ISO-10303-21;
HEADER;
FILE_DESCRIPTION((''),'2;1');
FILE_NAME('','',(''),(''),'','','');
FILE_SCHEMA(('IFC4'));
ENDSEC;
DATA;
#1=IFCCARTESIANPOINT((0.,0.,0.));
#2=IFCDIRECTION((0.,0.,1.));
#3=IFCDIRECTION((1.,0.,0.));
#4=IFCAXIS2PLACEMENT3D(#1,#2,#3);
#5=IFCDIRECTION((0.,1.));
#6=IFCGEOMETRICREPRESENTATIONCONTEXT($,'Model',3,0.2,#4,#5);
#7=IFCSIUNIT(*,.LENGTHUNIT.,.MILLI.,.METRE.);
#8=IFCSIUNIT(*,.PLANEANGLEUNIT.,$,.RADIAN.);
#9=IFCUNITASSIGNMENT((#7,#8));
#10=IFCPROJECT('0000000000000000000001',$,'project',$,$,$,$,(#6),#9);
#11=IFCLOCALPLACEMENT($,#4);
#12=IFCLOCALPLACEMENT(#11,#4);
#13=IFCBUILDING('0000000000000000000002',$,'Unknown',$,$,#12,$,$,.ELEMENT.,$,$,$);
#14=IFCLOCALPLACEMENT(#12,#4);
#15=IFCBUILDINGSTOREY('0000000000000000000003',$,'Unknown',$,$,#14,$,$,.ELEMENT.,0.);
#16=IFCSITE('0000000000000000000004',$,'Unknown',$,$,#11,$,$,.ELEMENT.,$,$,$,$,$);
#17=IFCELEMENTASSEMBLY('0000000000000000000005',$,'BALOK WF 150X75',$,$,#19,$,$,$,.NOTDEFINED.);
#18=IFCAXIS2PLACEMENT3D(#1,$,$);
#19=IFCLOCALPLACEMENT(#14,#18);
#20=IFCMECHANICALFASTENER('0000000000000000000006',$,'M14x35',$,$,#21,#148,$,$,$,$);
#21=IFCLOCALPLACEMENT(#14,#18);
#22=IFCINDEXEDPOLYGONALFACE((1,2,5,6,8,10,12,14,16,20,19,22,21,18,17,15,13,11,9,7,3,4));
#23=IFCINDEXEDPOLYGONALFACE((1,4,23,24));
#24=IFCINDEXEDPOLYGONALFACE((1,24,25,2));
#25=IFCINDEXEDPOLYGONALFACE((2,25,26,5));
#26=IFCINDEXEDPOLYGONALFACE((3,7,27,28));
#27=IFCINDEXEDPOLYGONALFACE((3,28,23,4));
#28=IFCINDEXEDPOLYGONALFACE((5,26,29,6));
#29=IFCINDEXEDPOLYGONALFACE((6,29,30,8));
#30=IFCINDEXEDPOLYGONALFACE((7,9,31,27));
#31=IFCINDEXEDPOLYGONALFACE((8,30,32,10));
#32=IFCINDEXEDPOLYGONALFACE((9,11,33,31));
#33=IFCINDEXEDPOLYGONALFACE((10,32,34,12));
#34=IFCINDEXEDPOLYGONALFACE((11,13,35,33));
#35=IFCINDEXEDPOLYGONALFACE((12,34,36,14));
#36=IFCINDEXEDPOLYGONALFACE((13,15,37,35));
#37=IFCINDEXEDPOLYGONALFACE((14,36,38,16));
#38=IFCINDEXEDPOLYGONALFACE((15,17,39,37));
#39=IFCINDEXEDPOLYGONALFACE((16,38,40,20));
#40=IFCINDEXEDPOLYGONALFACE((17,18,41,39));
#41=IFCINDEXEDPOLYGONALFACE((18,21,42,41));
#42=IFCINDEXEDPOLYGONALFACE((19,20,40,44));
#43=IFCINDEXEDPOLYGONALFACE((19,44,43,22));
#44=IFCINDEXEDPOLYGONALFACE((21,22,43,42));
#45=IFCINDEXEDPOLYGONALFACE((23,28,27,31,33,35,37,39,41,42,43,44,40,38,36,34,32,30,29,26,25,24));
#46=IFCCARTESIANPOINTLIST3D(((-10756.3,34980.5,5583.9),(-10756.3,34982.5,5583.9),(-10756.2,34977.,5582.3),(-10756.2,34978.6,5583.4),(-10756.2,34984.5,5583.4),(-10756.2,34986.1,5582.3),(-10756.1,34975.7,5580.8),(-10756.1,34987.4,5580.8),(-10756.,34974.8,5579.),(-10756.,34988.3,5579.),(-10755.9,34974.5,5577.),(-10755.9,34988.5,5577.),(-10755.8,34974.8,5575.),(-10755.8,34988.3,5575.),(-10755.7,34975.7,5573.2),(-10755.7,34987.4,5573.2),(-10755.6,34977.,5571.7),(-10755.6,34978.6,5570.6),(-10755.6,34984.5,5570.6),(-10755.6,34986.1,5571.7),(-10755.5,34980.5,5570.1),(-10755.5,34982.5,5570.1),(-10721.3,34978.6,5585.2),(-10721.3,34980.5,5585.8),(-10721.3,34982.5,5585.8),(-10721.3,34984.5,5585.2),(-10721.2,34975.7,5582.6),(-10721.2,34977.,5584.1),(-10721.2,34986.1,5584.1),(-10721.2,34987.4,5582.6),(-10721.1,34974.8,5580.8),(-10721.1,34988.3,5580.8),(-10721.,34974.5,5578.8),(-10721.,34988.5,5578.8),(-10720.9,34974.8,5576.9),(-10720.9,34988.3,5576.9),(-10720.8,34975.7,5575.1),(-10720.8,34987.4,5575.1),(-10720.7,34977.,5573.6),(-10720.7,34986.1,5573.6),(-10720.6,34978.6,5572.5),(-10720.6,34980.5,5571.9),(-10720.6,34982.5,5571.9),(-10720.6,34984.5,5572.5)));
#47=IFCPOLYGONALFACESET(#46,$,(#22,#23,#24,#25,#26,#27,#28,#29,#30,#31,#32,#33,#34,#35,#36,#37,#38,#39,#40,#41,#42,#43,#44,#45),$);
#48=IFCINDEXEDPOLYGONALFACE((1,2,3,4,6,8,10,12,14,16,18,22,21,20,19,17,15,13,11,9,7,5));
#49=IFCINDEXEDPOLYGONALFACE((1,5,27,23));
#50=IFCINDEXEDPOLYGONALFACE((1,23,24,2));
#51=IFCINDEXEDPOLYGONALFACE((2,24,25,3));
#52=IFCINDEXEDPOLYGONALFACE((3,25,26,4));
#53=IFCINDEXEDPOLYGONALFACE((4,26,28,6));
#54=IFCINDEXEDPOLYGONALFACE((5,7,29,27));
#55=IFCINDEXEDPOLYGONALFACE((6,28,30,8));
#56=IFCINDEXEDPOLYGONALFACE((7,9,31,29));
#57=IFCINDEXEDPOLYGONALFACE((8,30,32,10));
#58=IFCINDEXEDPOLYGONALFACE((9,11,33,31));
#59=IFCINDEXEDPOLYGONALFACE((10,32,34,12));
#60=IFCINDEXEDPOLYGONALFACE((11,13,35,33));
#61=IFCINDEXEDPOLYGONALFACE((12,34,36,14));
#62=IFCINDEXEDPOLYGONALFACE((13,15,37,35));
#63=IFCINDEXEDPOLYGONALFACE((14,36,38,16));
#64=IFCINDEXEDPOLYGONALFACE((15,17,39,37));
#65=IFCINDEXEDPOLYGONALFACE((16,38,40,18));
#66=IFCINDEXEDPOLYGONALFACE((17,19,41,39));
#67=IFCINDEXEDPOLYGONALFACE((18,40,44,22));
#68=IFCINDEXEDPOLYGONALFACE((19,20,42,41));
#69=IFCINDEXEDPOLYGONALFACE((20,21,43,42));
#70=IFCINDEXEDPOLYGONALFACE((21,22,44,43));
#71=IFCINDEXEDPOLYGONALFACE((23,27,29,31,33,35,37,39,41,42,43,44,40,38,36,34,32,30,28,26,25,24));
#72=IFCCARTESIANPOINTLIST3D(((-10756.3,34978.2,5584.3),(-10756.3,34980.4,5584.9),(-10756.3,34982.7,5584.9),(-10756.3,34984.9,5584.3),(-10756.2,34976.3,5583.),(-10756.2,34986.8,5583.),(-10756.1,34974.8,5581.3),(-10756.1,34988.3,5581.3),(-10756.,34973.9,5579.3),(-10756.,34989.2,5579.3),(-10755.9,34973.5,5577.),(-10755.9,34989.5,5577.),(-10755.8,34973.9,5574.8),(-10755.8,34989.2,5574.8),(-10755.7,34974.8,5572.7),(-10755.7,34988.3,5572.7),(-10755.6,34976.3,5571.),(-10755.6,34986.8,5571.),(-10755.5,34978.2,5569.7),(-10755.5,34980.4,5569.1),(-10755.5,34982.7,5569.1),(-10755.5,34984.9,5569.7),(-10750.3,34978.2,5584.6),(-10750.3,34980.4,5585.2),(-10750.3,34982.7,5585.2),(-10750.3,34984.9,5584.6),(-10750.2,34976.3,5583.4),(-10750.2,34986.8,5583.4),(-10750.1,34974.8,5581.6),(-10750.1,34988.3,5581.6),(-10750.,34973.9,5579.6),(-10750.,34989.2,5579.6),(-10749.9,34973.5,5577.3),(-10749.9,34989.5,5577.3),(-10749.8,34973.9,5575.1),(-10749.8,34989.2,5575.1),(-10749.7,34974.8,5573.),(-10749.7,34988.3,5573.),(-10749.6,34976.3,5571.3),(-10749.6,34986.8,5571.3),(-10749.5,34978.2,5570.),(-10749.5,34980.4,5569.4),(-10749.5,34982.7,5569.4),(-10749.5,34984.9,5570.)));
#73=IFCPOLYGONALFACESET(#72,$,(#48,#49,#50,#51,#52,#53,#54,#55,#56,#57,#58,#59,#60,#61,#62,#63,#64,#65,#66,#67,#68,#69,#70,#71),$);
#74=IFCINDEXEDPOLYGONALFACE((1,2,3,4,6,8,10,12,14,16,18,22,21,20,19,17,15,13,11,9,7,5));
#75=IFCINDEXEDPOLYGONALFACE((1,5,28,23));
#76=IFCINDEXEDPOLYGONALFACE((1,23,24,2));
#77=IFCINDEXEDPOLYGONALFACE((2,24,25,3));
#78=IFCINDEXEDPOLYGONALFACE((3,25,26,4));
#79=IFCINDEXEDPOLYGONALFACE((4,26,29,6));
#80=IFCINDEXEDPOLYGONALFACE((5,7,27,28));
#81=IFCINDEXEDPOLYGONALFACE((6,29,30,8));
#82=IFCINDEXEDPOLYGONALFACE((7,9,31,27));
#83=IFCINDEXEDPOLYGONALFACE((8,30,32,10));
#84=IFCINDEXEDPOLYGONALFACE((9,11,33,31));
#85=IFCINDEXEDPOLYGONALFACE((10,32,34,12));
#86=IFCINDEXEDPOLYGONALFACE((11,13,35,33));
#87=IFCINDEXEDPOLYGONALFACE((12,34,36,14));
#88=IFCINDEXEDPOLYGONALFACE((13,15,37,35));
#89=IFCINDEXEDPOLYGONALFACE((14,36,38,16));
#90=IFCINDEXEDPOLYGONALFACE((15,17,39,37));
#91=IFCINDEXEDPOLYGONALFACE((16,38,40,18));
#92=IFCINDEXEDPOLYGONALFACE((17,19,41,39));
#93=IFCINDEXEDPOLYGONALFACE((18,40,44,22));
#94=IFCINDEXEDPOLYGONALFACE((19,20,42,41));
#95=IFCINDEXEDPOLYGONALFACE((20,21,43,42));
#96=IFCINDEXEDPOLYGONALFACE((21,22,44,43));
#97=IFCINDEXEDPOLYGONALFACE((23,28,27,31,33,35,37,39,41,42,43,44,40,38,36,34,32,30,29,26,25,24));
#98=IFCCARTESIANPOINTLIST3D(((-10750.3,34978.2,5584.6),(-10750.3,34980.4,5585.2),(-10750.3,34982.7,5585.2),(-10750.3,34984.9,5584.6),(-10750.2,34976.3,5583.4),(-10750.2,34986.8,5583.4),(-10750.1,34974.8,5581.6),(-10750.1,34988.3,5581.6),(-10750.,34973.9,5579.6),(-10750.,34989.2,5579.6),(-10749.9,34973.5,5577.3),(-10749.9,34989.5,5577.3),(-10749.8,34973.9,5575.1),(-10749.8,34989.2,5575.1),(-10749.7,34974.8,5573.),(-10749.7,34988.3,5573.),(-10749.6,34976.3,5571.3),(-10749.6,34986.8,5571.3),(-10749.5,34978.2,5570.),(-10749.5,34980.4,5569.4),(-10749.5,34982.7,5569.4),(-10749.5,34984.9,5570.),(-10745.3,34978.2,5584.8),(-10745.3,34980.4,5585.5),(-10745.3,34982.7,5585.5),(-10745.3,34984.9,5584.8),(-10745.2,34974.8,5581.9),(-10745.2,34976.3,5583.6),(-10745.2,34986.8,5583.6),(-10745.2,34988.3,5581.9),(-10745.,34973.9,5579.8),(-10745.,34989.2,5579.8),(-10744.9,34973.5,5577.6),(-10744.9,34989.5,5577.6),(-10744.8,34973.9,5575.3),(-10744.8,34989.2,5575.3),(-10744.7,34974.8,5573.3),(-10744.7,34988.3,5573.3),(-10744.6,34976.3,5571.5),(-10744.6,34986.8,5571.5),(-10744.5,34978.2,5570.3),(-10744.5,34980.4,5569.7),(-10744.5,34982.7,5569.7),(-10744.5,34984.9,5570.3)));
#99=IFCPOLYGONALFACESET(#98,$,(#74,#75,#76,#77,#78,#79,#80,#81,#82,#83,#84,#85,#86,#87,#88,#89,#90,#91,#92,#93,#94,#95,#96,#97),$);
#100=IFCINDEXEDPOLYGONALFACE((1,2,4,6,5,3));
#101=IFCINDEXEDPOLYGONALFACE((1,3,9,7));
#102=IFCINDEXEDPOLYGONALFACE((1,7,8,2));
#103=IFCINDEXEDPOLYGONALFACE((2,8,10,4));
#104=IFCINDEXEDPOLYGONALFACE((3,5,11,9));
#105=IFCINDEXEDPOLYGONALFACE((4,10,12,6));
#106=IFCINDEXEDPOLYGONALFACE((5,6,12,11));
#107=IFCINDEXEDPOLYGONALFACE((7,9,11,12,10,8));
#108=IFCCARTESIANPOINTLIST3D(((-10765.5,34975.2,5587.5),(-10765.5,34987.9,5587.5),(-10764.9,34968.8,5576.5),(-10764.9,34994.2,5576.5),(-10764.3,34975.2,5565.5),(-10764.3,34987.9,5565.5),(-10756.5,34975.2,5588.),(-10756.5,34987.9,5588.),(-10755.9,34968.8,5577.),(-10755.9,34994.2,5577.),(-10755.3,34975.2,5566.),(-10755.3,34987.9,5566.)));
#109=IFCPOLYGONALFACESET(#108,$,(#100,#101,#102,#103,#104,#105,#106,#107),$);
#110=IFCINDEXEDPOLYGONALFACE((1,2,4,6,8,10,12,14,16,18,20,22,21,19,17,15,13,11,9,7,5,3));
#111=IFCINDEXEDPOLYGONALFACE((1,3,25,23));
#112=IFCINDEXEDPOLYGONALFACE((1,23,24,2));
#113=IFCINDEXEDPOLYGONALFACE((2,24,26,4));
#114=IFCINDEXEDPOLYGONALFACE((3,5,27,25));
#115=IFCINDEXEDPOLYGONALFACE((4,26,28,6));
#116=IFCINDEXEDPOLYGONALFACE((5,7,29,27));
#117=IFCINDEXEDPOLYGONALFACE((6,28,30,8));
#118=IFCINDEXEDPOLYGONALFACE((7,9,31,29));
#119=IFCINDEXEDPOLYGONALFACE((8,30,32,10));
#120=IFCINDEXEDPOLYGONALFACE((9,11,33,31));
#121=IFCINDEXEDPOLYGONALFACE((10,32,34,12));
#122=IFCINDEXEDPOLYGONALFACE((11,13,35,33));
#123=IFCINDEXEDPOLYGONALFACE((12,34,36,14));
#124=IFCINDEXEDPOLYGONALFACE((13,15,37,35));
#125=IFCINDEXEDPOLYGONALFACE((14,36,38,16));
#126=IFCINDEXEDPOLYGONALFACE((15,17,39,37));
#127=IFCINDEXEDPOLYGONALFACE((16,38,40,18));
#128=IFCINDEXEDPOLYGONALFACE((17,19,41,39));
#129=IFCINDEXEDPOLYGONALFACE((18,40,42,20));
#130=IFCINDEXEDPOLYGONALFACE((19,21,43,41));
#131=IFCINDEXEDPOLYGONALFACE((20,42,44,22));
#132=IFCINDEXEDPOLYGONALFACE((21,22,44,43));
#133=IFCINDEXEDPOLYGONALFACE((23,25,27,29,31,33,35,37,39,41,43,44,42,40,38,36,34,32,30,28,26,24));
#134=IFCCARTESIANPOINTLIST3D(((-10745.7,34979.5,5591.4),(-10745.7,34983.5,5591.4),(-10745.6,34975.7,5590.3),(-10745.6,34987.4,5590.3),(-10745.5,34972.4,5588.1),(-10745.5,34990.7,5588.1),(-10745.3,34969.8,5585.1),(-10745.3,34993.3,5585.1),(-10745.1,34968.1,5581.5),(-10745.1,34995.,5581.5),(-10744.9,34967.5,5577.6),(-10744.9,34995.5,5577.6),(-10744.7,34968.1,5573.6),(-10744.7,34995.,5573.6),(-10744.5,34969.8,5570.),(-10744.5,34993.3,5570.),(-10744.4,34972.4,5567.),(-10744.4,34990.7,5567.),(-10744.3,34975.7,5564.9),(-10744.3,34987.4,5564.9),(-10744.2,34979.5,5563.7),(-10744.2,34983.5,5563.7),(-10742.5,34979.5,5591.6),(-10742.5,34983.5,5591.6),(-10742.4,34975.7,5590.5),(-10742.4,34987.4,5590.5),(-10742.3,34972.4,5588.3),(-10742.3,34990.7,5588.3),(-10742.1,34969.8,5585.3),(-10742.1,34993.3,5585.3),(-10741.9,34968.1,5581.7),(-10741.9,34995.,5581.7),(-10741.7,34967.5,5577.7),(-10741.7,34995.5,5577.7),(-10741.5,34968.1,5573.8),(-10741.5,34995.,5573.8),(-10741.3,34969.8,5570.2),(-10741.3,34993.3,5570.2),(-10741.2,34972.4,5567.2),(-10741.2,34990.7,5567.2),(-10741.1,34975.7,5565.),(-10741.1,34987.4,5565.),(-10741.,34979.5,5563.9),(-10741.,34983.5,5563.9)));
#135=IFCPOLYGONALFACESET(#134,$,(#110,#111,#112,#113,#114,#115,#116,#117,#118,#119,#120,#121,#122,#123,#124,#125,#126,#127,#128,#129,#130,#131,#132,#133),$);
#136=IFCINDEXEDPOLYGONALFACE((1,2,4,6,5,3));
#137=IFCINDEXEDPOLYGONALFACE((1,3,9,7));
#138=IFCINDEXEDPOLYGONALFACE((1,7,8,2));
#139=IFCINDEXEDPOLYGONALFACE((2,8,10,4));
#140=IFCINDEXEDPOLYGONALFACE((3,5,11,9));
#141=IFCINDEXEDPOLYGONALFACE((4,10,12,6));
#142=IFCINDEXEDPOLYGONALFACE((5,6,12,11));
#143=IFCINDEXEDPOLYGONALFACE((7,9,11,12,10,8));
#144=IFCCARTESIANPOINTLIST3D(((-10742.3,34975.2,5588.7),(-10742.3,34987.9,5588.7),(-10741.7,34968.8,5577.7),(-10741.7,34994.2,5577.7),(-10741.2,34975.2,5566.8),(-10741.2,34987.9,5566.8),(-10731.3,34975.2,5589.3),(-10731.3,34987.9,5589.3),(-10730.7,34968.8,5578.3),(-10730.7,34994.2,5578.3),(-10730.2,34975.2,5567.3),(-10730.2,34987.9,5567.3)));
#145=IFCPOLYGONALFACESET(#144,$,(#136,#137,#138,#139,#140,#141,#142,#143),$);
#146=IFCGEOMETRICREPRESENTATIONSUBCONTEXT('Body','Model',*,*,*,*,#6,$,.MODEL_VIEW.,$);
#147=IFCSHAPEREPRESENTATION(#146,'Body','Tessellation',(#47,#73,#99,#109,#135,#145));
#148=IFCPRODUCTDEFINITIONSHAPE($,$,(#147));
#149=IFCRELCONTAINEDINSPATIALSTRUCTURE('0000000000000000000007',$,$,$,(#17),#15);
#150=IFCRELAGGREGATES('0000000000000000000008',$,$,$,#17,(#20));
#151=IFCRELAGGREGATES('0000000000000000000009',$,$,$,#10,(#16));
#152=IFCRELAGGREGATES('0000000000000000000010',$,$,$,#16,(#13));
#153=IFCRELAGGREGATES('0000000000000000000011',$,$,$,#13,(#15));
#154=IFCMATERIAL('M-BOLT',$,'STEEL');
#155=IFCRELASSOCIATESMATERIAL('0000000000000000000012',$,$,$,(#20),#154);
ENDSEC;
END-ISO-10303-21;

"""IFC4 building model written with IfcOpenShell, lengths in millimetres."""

from ifc_helpers import new_model, si_unit, direction, frame, origin_with_axes, place, context, subcontext, project, spatial, line, arc, indexed_curve, outline, extrude, source, transform, mapped, material, element, aggregate, save


model = new_model("IFC4")

# Units and contexts
model_context = context("Model", 3, precision=0.2, world=origin_with_axes(), true_north=direction((0.0, 1.0)))
body_context = subcontext(model_context, "Body", "Model", "MODEL_VIEW")
ifc_project = project(units=[si_unit("LENGTHUNIT", "METRE", prefix="MILLI"), si_unit("PLANEANGLEUNIT", "RADIAN")], contexts=[model_context])

# Site, building, storey
site_placement = place(None, origin_with_axes())
site = spatial("IfcSite", under=ifc_project, at=site_placement, Name="Unknown", CompositionType="ELEMENT")
building_placement = place(site_placement, origin_with_axes())
building = spatial("IfcBuilding", under=site, at=building_placement, Name="Unknown", CompositionType="ELEMENT")
storey_placement = place(building_placement, origin_with_axes())
storey = spatial("IfcBuildingStorey", under=building, at=storey_placement, Name="Unknown", CompositionType="ELEMENT", Elevation=0.0)

# Shared definitions
ifc_material_1 = material(Name="M-BOLT", Category="STEEL")

# Element assembly, mechanical fastener
shared_shape_1 = source(origin_with_axes(), body_context, "Body", "SweptSolid", [
    extrude(outline(indexed_curve([(7.0, 0.0), (0.0, 7.0), (-7.0, 0.0), (0.0, -7.0)], segments=[arc(1, 2, 3), arc(3, 4, 1)])), frame((0.0, 0.0, 0.0), z_axis=(0.0, 0.0, -1.0), x_axis=(0.0, 1.0, 0.0)), (0.0, 0.0, 1.0), 35.0),
    extrude(outline(indexed_curve([(8.0, 0.0), (0.0, 8.0), (-8.0, 0.0), (0.0, -8.0)], segments=[arc(1, 2, 3), arc(3, 4, 1)])), frame((0.0, 0.0, 0.0), z_axis=(0.0, 0.0, -1.0), x_axis=(0.0, 1.0, 0.0)), (0.0, 0.0, 1.0), 6.0),
    extrude(outline(indexed_curve([(8.0, 0.0), (0.0, 8.0), (-8.0, 0.0), (0.0, -8.0)], segments=[arc(1, 2, 3), arc(3, 4, 1)])), frame((0.0, 0.0, -6.0), z_axis=(0.0, 0.0, -1.0), x_axis=(0.0, 1.0, 0.0)), (0.0, 0.0, 1.0), 5.0),
    extrude(outline(indexed_curve([(12.7, 0.0), (6.4, 11.0), (-6.4, 11.0), (-12.7, 0.0), (-6.4, -11.0), (6.4, -11.0)], segments=[line(1, 2, 3, 4, 5, 6, 1)])), frame((0.0, 0.0, 9.0), z_axis=(0.0, 0.0, -1.0), x_axis=(0.0, 1.0, 0.0)), (0.0, 0.0, 1.0), 9.0),
    extrude(outline(indexed_curve([(14.0, 0.0), (0.0, 14.0), (-14.0, 0.0), (0.0, -14.0)], segments=[arc(1, 2, 3), arc(3, 4, 1)])), frame((0.0, 0.0, -11.0), z_axis=(0.0, 0.0, -1.0), x_axis=(0.0, 1.0, 0.0)), (0.0, 0.0, 1.0), 3.2),
    extrude(outline(indexed_curve([(12.7, 0.0), (6.4, 11.0), (-6.4, 11.0), (-12.7, 0.0), (-6.4, -11.0), (6.4, -11.0)], segments=[line(1, 2, 3, 4, 5, 6, 1)])), frame((0.0, 0.0, -14.2), z_axis=(0.0, 0.0, -1.0), x_axis=(0.0, 1.0, 0.0)), (0.0, 0.0, 1.0), 11.0),
])
assembly_1_placement = place(storey_placement, frame((-10746.1, 35225.4, 5552.5), z_axis=(-0.99863, 0.0, -0.052336), x_axis=(0.0, -1.0, 0.0)))
assembly_1 = element("IfcElementAssembly", 1, at=assembly_1_placement, inside=storey, Name="BALOK WF 150X75", PredefinedType="NOTDEFINED")
mechanical_fastener_1_placement = place(assembly_1_placement, frame((243.9, 25.0, 8.5), z_axis=(0.000006, 0.0, 1.0), x_axis=(0.0, -1.0, 0.0)))
mechanical_fastener_1 = element("IfcMechanicalFastener", 2, at=mechanical_fastener_1_placement, material=ifc_material_1, Name="M14x35", context=body_context, shape_type="MappedRepresentation", body=[
    mapped(shared_shape_1, transform((0.0, 0.0, 0.0))),
])

aggregate(assembly_1, [mechanical_fastener_1])

save(model, "model.ifc")
